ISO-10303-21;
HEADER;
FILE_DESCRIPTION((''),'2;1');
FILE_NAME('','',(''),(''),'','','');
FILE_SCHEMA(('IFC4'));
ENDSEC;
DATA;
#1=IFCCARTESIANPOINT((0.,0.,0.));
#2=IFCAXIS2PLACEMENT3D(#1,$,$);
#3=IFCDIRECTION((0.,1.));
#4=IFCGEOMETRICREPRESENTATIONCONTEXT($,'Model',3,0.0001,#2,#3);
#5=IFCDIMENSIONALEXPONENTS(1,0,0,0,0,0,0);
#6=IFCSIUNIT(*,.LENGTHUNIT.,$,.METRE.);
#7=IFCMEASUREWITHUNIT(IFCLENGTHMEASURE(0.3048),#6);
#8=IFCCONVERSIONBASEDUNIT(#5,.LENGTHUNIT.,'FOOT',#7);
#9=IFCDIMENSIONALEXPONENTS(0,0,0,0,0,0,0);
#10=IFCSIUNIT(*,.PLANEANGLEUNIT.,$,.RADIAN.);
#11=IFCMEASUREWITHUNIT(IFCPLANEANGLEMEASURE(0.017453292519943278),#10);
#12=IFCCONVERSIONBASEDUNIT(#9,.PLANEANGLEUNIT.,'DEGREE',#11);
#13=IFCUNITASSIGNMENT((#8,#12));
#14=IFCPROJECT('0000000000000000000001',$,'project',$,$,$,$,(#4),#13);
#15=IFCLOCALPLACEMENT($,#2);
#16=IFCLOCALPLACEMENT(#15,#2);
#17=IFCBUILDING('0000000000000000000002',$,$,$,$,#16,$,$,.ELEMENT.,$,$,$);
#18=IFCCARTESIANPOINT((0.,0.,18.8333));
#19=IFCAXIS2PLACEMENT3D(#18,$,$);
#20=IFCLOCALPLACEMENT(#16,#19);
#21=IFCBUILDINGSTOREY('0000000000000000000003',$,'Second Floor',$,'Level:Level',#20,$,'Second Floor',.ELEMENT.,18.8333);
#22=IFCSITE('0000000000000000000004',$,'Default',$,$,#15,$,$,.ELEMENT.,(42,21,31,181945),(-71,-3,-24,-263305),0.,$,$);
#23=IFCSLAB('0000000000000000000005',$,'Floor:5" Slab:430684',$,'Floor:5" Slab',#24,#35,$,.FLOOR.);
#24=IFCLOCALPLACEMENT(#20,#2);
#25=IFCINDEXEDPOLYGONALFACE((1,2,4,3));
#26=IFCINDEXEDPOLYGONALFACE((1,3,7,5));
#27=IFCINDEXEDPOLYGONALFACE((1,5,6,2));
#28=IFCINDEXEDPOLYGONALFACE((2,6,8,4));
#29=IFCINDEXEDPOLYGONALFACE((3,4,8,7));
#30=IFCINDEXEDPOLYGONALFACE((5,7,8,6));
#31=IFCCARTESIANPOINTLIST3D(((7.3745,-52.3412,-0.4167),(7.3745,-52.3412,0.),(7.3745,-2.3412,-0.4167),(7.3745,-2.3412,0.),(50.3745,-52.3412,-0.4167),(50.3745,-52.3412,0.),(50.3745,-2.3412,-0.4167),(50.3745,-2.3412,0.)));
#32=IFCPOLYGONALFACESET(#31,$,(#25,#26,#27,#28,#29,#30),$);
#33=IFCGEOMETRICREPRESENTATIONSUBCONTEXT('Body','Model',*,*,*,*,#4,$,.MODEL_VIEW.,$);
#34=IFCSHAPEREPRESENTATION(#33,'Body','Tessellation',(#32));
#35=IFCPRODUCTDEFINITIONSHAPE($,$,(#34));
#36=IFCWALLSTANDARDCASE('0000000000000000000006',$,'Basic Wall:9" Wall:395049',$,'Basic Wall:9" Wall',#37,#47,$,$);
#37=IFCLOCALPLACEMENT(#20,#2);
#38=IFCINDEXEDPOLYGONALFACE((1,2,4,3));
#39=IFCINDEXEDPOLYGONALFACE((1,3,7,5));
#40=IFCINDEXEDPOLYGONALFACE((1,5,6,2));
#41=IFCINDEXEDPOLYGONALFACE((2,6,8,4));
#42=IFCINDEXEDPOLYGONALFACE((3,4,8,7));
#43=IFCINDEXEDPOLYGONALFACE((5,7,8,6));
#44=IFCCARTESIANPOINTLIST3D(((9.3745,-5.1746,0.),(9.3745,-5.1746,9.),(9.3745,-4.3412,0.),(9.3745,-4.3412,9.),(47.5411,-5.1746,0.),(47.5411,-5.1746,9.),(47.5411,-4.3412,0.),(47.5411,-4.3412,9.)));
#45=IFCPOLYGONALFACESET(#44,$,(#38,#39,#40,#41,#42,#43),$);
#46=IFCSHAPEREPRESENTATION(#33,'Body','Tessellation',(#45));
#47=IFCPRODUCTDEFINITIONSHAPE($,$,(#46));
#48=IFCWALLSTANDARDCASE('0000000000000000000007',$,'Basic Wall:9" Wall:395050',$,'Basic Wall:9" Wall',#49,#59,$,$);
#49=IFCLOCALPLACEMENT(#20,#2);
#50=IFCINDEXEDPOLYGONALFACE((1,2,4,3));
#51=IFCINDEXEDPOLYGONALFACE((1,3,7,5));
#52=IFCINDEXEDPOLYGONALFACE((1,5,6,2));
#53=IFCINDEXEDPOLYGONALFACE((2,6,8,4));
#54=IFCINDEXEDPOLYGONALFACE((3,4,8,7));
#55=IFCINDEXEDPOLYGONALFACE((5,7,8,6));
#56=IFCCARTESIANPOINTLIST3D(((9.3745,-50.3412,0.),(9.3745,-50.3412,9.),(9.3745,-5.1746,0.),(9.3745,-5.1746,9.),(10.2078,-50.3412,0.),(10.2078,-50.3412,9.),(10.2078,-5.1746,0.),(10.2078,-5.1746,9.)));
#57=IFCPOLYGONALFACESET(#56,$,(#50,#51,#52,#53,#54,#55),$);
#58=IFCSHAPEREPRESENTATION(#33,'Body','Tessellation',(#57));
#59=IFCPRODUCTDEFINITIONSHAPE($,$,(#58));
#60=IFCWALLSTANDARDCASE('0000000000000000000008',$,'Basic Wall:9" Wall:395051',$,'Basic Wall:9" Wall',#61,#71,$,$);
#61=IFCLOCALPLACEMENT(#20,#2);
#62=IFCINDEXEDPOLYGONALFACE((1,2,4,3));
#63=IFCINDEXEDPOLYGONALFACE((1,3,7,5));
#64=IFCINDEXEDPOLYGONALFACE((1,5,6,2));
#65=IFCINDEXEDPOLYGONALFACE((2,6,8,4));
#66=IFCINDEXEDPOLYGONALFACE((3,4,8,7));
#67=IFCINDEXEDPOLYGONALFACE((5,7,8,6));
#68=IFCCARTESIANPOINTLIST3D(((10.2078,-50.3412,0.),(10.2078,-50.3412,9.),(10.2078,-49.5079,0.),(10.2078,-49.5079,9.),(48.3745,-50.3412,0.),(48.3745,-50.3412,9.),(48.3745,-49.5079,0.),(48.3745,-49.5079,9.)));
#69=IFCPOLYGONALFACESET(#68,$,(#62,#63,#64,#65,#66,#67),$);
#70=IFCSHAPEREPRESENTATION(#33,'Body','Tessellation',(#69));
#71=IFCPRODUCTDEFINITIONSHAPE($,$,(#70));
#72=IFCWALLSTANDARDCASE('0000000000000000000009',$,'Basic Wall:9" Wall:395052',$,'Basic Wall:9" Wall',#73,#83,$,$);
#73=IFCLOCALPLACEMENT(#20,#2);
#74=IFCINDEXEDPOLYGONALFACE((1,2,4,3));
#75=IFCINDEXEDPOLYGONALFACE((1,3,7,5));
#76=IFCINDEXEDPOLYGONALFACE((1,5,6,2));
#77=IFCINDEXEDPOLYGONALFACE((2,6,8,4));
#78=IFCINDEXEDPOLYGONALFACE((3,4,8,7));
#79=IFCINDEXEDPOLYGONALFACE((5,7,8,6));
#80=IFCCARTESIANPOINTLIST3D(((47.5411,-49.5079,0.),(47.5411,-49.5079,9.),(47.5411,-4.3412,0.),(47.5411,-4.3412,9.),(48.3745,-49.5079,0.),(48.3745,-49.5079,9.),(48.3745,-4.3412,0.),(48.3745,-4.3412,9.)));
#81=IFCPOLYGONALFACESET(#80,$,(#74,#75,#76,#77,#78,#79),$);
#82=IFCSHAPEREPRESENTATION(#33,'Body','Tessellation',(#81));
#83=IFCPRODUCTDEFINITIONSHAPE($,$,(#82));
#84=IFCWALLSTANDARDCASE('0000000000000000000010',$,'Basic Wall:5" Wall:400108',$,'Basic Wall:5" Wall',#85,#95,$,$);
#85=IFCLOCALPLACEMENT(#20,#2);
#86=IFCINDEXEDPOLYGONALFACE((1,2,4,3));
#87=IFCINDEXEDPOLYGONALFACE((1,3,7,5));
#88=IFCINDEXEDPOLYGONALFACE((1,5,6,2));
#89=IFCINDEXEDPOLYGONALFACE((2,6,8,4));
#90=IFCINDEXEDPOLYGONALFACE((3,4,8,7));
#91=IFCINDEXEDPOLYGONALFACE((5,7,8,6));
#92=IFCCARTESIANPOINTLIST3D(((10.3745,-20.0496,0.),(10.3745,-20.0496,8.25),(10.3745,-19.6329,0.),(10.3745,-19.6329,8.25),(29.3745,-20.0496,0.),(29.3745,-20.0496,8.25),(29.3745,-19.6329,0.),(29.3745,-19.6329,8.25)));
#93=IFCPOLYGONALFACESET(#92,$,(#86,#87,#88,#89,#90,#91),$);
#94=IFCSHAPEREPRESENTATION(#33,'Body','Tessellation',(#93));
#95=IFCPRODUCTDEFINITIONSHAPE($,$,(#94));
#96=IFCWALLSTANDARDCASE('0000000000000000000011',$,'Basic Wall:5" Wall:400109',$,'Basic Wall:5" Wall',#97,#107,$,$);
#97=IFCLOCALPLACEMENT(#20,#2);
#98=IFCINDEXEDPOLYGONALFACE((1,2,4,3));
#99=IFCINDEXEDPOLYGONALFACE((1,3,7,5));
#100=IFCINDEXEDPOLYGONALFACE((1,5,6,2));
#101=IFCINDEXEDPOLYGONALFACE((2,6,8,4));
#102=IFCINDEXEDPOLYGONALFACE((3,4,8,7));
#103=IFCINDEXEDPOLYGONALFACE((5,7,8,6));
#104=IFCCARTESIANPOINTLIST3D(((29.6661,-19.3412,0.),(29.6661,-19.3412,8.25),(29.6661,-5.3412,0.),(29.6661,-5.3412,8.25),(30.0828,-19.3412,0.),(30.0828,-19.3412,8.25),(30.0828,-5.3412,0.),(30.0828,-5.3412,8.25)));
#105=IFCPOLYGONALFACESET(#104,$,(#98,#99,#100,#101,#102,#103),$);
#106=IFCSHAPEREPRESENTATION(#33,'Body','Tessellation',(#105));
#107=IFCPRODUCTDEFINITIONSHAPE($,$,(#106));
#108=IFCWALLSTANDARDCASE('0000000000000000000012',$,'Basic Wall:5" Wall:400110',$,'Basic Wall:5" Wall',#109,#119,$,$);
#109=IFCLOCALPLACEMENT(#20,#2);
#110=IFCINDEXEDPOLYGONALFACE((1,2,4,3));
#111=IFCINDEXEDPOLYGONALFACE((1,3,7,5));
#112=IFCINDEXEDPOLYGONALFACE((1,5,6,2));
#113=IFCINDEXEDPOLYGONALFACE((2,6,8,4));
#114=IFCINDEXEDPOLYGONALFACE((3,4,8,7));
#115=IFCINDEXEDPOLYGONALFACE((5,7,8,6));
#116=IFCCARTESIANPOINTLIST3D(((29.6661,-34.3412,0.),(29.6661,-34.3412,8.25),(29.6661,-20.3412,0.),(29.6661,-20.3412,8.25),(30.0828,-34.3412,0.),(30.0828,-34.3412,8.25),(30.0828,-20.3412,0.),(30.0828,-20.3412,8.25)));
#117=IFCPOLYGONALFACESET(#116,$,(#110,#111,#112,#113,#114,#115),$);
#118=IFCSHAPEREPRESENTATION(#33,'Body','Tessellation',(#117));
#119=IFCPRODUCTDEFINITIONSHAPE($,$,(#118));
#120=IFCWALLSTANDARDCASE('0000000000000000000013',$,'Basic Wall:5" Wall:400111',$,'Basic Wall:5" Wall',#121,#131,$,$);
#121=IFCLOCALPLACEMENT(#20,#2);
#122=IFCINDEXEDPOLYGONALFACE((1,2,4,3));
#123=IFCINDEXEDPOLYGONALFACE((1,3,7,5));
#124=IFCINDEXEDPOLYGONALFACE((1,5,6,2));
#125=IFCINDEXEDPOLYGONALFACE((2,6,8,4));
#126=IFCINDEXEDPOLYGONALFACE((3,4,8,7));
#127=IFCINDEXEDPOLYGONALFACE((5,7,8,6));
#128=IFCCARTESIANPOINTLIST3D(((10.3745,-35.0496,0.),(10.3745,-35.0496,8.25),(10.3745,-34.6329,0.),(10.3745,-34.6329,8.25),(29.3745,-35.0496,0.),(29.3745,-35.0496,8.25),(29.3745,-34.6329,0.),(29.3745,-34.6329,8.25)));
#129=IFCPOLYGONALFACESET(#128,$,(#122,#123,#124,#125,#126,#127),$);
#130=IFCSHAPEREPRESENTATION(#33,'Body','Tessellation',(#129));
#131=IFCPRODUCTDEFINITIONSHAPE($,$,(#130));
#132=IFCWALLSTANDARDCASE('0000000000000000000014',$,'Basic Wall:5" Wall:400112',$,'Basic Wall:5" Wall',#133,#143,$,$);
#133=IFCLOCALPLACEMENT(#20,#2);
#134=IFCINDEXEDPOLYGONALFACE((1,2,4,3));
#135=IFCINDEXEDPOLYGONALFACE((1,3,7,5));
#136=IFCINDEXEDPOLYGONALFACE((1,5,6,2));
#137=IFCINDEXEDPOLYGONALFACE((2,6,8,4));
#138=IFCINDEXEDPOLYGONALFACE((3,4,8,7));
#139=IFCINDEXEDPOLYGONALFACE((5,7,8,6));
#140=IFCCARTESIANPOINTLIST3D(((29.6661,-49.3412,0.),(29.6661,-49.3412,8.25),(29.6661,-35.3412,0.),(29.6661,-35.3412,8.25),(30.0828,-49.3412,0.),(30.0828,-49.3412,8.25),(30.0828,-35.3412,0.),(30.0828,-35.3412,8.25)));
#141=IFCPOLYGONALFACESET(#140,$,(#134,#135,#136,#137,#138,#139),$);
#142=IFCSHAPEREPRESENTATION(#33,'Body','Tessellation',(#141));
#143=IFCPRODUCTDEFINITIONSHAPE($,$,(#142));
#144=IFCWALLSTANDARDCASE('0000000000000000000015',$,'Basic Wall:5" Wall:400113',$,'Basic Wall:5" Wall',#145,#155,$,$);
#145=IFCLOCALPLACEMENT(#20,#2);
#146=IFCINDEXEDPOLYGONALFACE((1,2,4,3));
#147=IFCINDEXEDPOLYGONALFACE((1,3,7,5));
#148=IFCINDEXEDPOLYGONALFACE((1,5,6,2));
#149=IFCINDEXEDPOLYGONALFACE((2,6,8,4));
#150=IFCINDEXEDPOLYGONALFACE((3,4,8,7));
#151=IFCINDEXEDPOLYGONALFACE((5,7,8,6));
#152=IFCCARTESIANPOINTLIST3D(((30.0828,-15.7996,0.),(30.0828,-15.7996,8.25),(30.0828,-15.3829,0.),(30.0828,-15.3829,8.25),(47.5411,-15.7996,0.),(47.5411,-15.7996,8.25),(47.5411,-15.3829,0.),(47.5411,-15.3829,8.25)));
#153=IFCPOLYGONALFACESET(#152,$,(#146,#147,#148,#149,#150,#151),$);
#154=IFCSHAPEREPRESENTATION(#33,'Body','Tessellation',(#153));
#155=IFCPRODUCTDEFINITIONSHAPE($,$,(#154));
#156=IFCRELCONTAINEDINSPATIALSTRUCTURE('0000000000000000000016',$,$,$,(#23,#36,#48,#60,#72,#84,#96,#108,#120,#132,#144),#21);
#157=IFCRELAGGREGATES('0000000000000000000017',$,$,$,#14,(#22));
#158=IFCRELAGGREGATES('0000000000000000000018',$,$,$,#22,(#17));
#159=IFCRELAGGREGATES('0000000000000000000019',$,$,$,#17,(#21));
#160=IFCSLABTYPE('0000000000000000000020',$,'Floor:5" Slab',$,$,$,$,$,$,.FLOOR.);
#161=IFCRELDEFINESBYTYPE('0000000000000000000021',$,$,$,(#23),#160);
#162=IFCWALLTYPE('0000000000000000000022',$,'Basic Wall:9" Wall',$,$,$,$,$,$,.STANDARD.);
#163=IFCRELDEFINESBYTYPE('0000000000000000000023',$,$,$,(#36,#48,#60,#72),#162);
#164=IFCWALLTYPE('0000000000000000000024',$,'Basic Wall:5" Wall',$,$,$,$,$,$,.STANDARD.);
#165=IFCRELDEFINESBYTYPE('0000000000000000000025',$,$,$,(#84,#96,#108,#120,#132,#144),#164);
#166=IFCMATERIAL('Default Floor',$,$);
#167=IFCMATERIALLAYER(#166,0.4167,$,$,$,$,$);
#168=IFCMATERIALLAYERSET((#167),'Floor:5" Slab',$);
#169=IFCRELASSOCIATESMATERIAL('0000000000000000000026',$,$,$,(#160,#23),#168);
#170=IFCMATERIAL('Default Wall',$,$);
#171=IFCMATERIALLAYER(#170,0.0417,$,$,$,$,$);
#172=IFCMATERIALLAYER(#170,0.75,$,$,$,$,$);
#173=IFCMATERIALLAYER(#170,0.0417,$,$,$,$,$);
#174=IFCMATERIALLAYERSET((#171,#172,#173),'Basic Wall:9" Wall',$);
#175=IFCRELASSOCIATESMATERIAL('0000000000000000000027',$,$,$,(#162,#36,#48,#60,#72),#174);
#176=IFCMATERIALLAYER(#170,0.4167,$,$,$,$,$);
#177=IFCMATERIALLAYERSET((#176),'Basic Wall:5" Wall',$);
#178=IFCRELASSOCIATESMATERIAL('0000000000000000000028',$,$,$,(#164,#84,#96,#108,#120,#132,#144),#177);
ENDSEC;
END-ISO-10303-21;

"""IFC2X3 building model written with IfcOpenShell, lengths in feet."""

from ifc_helpers import new_model, entity, si_unit, converted_unit, direction, frame, frame_2d, origin, origin_2d_with_axis, place, context, subcontext, project, spatial, rectangle, extrude, material, layer, layer_set, layer_usage, type_object, element, save


model = new_model("IFC2X3")

# Units and contexts
model_context = context("Model", 3, precision=0.0001, world=origin(), true_north=direction((0.0, 1.0)))
body_context = subcontext(model_context, "Body", "Model", "MODEL_VIEW")
ifc_project = project(units=[converted_unit("LENGTHUNIT", "FOOT", entity("IfcLengthMeasure", 0.3048), si_unit("LENGTHUNIT", "METRE"), dimensions=[1, 0, 0, 0, 0, 0, 0]), converted_unit("PLANEANGLEUNIT", "DEGREE", entity("IfcPlaneAngleMeasure", 0.017453292519943278), si_unit("PLANEANGLEUNIT", "RADIAN"), dimensions=[0, 0, 0, 0, 0, 0, 0])], contexts=[model_context])

# Site, building, storey
site_placement = place(None, origin())
site = spatial("IfcSite", under=ifc_project, at=site_placement, Name="Default", CompositionType="ELEMENT", RefLatitude=(42, 21, 31, 181945), RefLongitude=(-71, -3, -24, -263305), RefElevation=0.0)
building_placement = place(site_placement, origin())
building = spatial("IfcBuilding", under=site, at=building_placement, CompositionType="ELEMENT")
storey_placement = place(building_placement, frame((0.0, 0.0, 18.8333)))
storey = spatial("IfcBuildingStorey", under=building, at=storey_placement, Name="Second Floor", ObjectType="Level:Level", LongName="Second Floor", CompositionType="ELEMENT", Elevation=18.8333)

# Slab
ifc_material_1 = material(Name="Default Floor")
ifc_layer_1 = layer(ifc_material_1, 0.4167)
ifc_layer_set_1 = layer_set([ifc_layer_1], Name="Floor:5\" Slab")
ifc_layer_usage_1 = layer_usage(ifc_layer_set_1, "AXIS3", "POSITIVE", 0.0)
slab_type = type_object("IfcSlabType", Name="Floor:5\" Slab", PredefinedType="FLOOR", material=ifc_layer_set_1)
slab_placement = place(storey_placement, origin())
element("IfcSlab", 1, at=slab_placement, inside=storey, type_object=slab_type, material=ifc_layer_usage_1, Name="Floor:5\" Slab:430684", ObjectType="Floor:5\" Slab", PredefinedType="FLOOR", context=body_context, shape_type="SweptSolid", body=[
    extrude(rectangle(XDim=50.0, YDim=43.0, at=origin_2d_with_axis()), frame((28.8745, -27.3412, 0.0), z_axis=(0.0, 0.0, -1.0), x_axis=(0.0, 1.0, 0.0)), (0.0, 0.0, 1.0), 0.4167),
])

# Walls
ifc_material_2 = material(Name="Default Wall")
ifc_layer_2 = layer(ifc_material_2, 0.0417)
ifc_layer_3 = layer(ifc_material_2, 0.75)
ifc_layer_4 = layer(ifc_material_2, 0.0417)
ifc_layer_set_2 = layer_set([ifc_layer_2, ifc_layer_3, ifc_layer_4], Name="Basic Wall:9\" Wall")
ifc_layer_usage_2 = layer_usage(ifc_layer_set_2, "AXIS2", "NEGATIVE", 0.4167)
wall_type_1 = type_object("IfcWallType", Name="Basic Wall:9\" Wall", PredefinedType="STANDARD", material=ifc_layer_set_2)
wall_1_placement = place(storey_placement, frame((9.3745, -4.7579, 0.0)))
element("IfcWallStandardCase", 2, at=wall_1_placement, inside=storey, type_object=wall_type_1, material=ifc_layer_usage_2, Name="Basic Wall:9\" Wall:395049", ObjectType="Basic Wall:9\" Wall", context=body_context, shape_type="SweptSolid", body=[
    extrude(rectangle(XDim=38.1667, YDim=0.8333, at=frame_2d((19.0833, 0.0), x_axis=(-1.0, 0.0))), origin(), (0.0, 0.0, 1.0), 9.0),
])
wall_2_placement = place(storey_placement, frame((9.7911, -50.3412, 0.0), z_axis=(0.0, 0.0, 1.0), x_axis=(0.0, 1.0, 0.0)))
element("IfcWallStandardCase", 3, at=wall_2_placement, inside=storey, type_object=wall_type_1, material=ifc_layer_usage_2, Name="Basic Wall:9\" Wall:395050", ObjectType="Basic Wall:9\" Wall", context=body_context, shape_type="SweptSolid", body=[
    extrude(rectangle(XDim=45.1667, YDim=0.8333, at=frame_2d((22.5833, 0.0), x_axis=(-1.0, 0.0))), origin(), (0.0, 0.0, 1.0), 9.0),
])
wall_3_placement = place(storey_placement, frame((48.3745, -49.9246, 0.0), z_axis=(0.0, 0.0, 1.0), x_axis=(-1.0, 0.0, 0.0)))
element("IfcWallStandardCase", 4, at=wall_3_placement, inside=storey, type_object=wall_type_1, material=ifc_layer_usage_2, Name="Basic Wall:9\" Wall:395051", ObjectType="Basic Wall:9\" Wall", context=body_context, shape_type="SweptSolid", body=[
    extrude(rectangle(XDim=38.1667, YDim=0.8333, at=frame_2d((19.0833, 0.0), x_axis=(-1.0, 0.0))), origin(), (0.0, 0.0, 1.0), 9.0),
])
wall_4_placement = place(storey_placement, frame((47.9578, -4.3412, 0.0), z_axis=(0.0, 0.0, 1.0), x_axis=(0.0, -1.0, 0.0)))
element("IfcWallStandardCase", 5, at=wall_4_placement, inside=storey, type_object=wall_type_1, material=ifc_layer_usage_2, Name="Basic Wall:9\" Wall:395052", ObjectType="Basic Wall:9\" Wall", context=body_context, shape_type="SweptSolid", body=[
    extrude(rectangle(XDim=45.1667, YDim=0.8333, at=frame_2d((22.5833, 0.0), x_axis=(-1.0, 0.0))), origin(), (0.0, 0.0, 1.0), 9.0),
])
ifc_layer_5 = layer(ifc_material_2, 0.4167)
ifc_layer_set_3 = layer_set([ifc_layer_5], Name="Basic Wall:5\" Wall")
ifc_layer_usage_3 = layer_usage(ifc_layer_set_3, "AXIS2", "NEGATIVE", 0.2083)
wall_type_2 = type_object("IfcWallType", Name="Basic Wall:5\" Wall", PredefinedType="STANDARD", material=ifc_layer_set_3)
wall_5_placement = place(storey_placement, frame((10.3745, -19.8412, 0.0)))
element("IfcWallStandardCase", 6, at=wall_5_placement, inside=storey, type_object=wall_type_2, material=ifc_layer_usage_3, Name="Basic Wall:5\" Wall:400108", ObjectType="Basic Wall:5\" Wall", context=body_context, shape_type="SweptSolid", body=[
    extrude(rectangle(XDim=19.0, YDim=0.4167, at=frame_2d((9.5, 0.0), x_axis=(-1.0, 0.0))), origin(), (0.0, 0.0, 1.0), 8.25),
])
wall_6_placement = place(storey_placement, frame((29.8745, -19.3412, 0.0), z_axis=(0.0, 0.0, 1.0), x_axis=(0.0, 1.0, 0.0)))
element("IfcWallStandardCase", 7, at=wall_6_placement, inside=storey, type_object=wall_type_2, material=ifc_layer_usage_3, Name="Basic Wall:5\" Wall:400109", ObjectType="Basic Wall:5\" Wall", context=body_context, shape_type="SweptSolid", body=[
    extrude(rectangle(XDim=14.0, YDim=0.4167, at=frame_2d((7.0, 0.0), x_axis=(-1.0, 0.0))), origin(), (0.0, 0.0, 1.0), 8.25),
])
wall_7_placement = place(storey_placement, frame((29.8745, -20.3412, 0.0), z_axis=(0.0, 0.0, 1.0), x_axis=(0.0, -1.0, 0.0)))
element("IfcWallStandardCase", 8, at=wall_7_placement, inside=storey, type_object=wall_type_2, material=ifc_layer_usage_3, Name="Basic Wall:5\" Wall:400110", ObjectType="Basic Wall:5\" Wall", context=body_context, shape_type="SweptSolid", body=[
    extrude(rectangle(XDim=14.0, YDim=0.4167, at=frame_2d((7.0, 0.0), x_axis=(-1.0, 0.0))), origin(), (0.0, 0.0, 1.0), 8.25),
])
wall_8_placement = place(storey_placement, frame((29.3745, -34.8412, 0.0), z_axis=(0.0, 0.0, 1.0), x_axis=(-1.0, 0.0, 0.0)))
element("IfcWallStandardCase", 9, at=wall_8_placement, inside=storey, type_object=wall_type_2, material=ifc_layer_usage_3, Name="Basic Wall:5\" Wall:400111", ObjectType="Basic Wall:5\" Wall", context=body_context, shape_type="SweptSolid", body=[
    extrude(rectangle(XDim=19.0, YDim=0.4167, at=frame_2d((9.5, 0.0), x_axis=(-1.0, 0.0))), origin(), (0.0, 0.0, 1.0), 8.25),
])
wall_9_placement = place(storey_placement, frame((29.8745, -35.3412, 0.0), z_axis=(0.0, 0.0, 1.0), x_axis=(0.0, -1.0, 0.0)))
element("IfcWallStandardCase", 10, at=wall_9_placement, inside=storey, type_object=wall_type_2, material=ifc_layer_usage_3, Name="Basic Wall:5\" Wall:400112", ObjectType="Basic Wall:5\" Wall", context=body_context, shape_type="SweptSolid", body=[
    extrude(rectangle(XDim=14.0, YDim=0.4167, at=frame_2d((7.0, 0.0), x_axis=(-1.0, 0.0))), origin(), (0.0, 0.0, 1.0), 8.25),
])
wall_10_placement = place(storey_placement, frame((30.0828, -15.5912, 0.0)))
element("IfcWallStandardCase", 11, at=wall_10_placement, inside=storey, type_object=wall_type_2, material=ifc_layer_usage_3, Name="Basic Wall:5\" Wall:400113", ObjectType="Basic Wall:5\" Wall", context=body_context, shape_type="SweptSolid", body=[
    extrude(rectangle(XDim=17.4583, YDim=0.4167, at=frame_2d((8.7292, 0.0), x_axis=(-1.0, 0.0))), origin(), (0.0, 0.0, 1.0), 8.25),
])

save(model, "model.ifc")
